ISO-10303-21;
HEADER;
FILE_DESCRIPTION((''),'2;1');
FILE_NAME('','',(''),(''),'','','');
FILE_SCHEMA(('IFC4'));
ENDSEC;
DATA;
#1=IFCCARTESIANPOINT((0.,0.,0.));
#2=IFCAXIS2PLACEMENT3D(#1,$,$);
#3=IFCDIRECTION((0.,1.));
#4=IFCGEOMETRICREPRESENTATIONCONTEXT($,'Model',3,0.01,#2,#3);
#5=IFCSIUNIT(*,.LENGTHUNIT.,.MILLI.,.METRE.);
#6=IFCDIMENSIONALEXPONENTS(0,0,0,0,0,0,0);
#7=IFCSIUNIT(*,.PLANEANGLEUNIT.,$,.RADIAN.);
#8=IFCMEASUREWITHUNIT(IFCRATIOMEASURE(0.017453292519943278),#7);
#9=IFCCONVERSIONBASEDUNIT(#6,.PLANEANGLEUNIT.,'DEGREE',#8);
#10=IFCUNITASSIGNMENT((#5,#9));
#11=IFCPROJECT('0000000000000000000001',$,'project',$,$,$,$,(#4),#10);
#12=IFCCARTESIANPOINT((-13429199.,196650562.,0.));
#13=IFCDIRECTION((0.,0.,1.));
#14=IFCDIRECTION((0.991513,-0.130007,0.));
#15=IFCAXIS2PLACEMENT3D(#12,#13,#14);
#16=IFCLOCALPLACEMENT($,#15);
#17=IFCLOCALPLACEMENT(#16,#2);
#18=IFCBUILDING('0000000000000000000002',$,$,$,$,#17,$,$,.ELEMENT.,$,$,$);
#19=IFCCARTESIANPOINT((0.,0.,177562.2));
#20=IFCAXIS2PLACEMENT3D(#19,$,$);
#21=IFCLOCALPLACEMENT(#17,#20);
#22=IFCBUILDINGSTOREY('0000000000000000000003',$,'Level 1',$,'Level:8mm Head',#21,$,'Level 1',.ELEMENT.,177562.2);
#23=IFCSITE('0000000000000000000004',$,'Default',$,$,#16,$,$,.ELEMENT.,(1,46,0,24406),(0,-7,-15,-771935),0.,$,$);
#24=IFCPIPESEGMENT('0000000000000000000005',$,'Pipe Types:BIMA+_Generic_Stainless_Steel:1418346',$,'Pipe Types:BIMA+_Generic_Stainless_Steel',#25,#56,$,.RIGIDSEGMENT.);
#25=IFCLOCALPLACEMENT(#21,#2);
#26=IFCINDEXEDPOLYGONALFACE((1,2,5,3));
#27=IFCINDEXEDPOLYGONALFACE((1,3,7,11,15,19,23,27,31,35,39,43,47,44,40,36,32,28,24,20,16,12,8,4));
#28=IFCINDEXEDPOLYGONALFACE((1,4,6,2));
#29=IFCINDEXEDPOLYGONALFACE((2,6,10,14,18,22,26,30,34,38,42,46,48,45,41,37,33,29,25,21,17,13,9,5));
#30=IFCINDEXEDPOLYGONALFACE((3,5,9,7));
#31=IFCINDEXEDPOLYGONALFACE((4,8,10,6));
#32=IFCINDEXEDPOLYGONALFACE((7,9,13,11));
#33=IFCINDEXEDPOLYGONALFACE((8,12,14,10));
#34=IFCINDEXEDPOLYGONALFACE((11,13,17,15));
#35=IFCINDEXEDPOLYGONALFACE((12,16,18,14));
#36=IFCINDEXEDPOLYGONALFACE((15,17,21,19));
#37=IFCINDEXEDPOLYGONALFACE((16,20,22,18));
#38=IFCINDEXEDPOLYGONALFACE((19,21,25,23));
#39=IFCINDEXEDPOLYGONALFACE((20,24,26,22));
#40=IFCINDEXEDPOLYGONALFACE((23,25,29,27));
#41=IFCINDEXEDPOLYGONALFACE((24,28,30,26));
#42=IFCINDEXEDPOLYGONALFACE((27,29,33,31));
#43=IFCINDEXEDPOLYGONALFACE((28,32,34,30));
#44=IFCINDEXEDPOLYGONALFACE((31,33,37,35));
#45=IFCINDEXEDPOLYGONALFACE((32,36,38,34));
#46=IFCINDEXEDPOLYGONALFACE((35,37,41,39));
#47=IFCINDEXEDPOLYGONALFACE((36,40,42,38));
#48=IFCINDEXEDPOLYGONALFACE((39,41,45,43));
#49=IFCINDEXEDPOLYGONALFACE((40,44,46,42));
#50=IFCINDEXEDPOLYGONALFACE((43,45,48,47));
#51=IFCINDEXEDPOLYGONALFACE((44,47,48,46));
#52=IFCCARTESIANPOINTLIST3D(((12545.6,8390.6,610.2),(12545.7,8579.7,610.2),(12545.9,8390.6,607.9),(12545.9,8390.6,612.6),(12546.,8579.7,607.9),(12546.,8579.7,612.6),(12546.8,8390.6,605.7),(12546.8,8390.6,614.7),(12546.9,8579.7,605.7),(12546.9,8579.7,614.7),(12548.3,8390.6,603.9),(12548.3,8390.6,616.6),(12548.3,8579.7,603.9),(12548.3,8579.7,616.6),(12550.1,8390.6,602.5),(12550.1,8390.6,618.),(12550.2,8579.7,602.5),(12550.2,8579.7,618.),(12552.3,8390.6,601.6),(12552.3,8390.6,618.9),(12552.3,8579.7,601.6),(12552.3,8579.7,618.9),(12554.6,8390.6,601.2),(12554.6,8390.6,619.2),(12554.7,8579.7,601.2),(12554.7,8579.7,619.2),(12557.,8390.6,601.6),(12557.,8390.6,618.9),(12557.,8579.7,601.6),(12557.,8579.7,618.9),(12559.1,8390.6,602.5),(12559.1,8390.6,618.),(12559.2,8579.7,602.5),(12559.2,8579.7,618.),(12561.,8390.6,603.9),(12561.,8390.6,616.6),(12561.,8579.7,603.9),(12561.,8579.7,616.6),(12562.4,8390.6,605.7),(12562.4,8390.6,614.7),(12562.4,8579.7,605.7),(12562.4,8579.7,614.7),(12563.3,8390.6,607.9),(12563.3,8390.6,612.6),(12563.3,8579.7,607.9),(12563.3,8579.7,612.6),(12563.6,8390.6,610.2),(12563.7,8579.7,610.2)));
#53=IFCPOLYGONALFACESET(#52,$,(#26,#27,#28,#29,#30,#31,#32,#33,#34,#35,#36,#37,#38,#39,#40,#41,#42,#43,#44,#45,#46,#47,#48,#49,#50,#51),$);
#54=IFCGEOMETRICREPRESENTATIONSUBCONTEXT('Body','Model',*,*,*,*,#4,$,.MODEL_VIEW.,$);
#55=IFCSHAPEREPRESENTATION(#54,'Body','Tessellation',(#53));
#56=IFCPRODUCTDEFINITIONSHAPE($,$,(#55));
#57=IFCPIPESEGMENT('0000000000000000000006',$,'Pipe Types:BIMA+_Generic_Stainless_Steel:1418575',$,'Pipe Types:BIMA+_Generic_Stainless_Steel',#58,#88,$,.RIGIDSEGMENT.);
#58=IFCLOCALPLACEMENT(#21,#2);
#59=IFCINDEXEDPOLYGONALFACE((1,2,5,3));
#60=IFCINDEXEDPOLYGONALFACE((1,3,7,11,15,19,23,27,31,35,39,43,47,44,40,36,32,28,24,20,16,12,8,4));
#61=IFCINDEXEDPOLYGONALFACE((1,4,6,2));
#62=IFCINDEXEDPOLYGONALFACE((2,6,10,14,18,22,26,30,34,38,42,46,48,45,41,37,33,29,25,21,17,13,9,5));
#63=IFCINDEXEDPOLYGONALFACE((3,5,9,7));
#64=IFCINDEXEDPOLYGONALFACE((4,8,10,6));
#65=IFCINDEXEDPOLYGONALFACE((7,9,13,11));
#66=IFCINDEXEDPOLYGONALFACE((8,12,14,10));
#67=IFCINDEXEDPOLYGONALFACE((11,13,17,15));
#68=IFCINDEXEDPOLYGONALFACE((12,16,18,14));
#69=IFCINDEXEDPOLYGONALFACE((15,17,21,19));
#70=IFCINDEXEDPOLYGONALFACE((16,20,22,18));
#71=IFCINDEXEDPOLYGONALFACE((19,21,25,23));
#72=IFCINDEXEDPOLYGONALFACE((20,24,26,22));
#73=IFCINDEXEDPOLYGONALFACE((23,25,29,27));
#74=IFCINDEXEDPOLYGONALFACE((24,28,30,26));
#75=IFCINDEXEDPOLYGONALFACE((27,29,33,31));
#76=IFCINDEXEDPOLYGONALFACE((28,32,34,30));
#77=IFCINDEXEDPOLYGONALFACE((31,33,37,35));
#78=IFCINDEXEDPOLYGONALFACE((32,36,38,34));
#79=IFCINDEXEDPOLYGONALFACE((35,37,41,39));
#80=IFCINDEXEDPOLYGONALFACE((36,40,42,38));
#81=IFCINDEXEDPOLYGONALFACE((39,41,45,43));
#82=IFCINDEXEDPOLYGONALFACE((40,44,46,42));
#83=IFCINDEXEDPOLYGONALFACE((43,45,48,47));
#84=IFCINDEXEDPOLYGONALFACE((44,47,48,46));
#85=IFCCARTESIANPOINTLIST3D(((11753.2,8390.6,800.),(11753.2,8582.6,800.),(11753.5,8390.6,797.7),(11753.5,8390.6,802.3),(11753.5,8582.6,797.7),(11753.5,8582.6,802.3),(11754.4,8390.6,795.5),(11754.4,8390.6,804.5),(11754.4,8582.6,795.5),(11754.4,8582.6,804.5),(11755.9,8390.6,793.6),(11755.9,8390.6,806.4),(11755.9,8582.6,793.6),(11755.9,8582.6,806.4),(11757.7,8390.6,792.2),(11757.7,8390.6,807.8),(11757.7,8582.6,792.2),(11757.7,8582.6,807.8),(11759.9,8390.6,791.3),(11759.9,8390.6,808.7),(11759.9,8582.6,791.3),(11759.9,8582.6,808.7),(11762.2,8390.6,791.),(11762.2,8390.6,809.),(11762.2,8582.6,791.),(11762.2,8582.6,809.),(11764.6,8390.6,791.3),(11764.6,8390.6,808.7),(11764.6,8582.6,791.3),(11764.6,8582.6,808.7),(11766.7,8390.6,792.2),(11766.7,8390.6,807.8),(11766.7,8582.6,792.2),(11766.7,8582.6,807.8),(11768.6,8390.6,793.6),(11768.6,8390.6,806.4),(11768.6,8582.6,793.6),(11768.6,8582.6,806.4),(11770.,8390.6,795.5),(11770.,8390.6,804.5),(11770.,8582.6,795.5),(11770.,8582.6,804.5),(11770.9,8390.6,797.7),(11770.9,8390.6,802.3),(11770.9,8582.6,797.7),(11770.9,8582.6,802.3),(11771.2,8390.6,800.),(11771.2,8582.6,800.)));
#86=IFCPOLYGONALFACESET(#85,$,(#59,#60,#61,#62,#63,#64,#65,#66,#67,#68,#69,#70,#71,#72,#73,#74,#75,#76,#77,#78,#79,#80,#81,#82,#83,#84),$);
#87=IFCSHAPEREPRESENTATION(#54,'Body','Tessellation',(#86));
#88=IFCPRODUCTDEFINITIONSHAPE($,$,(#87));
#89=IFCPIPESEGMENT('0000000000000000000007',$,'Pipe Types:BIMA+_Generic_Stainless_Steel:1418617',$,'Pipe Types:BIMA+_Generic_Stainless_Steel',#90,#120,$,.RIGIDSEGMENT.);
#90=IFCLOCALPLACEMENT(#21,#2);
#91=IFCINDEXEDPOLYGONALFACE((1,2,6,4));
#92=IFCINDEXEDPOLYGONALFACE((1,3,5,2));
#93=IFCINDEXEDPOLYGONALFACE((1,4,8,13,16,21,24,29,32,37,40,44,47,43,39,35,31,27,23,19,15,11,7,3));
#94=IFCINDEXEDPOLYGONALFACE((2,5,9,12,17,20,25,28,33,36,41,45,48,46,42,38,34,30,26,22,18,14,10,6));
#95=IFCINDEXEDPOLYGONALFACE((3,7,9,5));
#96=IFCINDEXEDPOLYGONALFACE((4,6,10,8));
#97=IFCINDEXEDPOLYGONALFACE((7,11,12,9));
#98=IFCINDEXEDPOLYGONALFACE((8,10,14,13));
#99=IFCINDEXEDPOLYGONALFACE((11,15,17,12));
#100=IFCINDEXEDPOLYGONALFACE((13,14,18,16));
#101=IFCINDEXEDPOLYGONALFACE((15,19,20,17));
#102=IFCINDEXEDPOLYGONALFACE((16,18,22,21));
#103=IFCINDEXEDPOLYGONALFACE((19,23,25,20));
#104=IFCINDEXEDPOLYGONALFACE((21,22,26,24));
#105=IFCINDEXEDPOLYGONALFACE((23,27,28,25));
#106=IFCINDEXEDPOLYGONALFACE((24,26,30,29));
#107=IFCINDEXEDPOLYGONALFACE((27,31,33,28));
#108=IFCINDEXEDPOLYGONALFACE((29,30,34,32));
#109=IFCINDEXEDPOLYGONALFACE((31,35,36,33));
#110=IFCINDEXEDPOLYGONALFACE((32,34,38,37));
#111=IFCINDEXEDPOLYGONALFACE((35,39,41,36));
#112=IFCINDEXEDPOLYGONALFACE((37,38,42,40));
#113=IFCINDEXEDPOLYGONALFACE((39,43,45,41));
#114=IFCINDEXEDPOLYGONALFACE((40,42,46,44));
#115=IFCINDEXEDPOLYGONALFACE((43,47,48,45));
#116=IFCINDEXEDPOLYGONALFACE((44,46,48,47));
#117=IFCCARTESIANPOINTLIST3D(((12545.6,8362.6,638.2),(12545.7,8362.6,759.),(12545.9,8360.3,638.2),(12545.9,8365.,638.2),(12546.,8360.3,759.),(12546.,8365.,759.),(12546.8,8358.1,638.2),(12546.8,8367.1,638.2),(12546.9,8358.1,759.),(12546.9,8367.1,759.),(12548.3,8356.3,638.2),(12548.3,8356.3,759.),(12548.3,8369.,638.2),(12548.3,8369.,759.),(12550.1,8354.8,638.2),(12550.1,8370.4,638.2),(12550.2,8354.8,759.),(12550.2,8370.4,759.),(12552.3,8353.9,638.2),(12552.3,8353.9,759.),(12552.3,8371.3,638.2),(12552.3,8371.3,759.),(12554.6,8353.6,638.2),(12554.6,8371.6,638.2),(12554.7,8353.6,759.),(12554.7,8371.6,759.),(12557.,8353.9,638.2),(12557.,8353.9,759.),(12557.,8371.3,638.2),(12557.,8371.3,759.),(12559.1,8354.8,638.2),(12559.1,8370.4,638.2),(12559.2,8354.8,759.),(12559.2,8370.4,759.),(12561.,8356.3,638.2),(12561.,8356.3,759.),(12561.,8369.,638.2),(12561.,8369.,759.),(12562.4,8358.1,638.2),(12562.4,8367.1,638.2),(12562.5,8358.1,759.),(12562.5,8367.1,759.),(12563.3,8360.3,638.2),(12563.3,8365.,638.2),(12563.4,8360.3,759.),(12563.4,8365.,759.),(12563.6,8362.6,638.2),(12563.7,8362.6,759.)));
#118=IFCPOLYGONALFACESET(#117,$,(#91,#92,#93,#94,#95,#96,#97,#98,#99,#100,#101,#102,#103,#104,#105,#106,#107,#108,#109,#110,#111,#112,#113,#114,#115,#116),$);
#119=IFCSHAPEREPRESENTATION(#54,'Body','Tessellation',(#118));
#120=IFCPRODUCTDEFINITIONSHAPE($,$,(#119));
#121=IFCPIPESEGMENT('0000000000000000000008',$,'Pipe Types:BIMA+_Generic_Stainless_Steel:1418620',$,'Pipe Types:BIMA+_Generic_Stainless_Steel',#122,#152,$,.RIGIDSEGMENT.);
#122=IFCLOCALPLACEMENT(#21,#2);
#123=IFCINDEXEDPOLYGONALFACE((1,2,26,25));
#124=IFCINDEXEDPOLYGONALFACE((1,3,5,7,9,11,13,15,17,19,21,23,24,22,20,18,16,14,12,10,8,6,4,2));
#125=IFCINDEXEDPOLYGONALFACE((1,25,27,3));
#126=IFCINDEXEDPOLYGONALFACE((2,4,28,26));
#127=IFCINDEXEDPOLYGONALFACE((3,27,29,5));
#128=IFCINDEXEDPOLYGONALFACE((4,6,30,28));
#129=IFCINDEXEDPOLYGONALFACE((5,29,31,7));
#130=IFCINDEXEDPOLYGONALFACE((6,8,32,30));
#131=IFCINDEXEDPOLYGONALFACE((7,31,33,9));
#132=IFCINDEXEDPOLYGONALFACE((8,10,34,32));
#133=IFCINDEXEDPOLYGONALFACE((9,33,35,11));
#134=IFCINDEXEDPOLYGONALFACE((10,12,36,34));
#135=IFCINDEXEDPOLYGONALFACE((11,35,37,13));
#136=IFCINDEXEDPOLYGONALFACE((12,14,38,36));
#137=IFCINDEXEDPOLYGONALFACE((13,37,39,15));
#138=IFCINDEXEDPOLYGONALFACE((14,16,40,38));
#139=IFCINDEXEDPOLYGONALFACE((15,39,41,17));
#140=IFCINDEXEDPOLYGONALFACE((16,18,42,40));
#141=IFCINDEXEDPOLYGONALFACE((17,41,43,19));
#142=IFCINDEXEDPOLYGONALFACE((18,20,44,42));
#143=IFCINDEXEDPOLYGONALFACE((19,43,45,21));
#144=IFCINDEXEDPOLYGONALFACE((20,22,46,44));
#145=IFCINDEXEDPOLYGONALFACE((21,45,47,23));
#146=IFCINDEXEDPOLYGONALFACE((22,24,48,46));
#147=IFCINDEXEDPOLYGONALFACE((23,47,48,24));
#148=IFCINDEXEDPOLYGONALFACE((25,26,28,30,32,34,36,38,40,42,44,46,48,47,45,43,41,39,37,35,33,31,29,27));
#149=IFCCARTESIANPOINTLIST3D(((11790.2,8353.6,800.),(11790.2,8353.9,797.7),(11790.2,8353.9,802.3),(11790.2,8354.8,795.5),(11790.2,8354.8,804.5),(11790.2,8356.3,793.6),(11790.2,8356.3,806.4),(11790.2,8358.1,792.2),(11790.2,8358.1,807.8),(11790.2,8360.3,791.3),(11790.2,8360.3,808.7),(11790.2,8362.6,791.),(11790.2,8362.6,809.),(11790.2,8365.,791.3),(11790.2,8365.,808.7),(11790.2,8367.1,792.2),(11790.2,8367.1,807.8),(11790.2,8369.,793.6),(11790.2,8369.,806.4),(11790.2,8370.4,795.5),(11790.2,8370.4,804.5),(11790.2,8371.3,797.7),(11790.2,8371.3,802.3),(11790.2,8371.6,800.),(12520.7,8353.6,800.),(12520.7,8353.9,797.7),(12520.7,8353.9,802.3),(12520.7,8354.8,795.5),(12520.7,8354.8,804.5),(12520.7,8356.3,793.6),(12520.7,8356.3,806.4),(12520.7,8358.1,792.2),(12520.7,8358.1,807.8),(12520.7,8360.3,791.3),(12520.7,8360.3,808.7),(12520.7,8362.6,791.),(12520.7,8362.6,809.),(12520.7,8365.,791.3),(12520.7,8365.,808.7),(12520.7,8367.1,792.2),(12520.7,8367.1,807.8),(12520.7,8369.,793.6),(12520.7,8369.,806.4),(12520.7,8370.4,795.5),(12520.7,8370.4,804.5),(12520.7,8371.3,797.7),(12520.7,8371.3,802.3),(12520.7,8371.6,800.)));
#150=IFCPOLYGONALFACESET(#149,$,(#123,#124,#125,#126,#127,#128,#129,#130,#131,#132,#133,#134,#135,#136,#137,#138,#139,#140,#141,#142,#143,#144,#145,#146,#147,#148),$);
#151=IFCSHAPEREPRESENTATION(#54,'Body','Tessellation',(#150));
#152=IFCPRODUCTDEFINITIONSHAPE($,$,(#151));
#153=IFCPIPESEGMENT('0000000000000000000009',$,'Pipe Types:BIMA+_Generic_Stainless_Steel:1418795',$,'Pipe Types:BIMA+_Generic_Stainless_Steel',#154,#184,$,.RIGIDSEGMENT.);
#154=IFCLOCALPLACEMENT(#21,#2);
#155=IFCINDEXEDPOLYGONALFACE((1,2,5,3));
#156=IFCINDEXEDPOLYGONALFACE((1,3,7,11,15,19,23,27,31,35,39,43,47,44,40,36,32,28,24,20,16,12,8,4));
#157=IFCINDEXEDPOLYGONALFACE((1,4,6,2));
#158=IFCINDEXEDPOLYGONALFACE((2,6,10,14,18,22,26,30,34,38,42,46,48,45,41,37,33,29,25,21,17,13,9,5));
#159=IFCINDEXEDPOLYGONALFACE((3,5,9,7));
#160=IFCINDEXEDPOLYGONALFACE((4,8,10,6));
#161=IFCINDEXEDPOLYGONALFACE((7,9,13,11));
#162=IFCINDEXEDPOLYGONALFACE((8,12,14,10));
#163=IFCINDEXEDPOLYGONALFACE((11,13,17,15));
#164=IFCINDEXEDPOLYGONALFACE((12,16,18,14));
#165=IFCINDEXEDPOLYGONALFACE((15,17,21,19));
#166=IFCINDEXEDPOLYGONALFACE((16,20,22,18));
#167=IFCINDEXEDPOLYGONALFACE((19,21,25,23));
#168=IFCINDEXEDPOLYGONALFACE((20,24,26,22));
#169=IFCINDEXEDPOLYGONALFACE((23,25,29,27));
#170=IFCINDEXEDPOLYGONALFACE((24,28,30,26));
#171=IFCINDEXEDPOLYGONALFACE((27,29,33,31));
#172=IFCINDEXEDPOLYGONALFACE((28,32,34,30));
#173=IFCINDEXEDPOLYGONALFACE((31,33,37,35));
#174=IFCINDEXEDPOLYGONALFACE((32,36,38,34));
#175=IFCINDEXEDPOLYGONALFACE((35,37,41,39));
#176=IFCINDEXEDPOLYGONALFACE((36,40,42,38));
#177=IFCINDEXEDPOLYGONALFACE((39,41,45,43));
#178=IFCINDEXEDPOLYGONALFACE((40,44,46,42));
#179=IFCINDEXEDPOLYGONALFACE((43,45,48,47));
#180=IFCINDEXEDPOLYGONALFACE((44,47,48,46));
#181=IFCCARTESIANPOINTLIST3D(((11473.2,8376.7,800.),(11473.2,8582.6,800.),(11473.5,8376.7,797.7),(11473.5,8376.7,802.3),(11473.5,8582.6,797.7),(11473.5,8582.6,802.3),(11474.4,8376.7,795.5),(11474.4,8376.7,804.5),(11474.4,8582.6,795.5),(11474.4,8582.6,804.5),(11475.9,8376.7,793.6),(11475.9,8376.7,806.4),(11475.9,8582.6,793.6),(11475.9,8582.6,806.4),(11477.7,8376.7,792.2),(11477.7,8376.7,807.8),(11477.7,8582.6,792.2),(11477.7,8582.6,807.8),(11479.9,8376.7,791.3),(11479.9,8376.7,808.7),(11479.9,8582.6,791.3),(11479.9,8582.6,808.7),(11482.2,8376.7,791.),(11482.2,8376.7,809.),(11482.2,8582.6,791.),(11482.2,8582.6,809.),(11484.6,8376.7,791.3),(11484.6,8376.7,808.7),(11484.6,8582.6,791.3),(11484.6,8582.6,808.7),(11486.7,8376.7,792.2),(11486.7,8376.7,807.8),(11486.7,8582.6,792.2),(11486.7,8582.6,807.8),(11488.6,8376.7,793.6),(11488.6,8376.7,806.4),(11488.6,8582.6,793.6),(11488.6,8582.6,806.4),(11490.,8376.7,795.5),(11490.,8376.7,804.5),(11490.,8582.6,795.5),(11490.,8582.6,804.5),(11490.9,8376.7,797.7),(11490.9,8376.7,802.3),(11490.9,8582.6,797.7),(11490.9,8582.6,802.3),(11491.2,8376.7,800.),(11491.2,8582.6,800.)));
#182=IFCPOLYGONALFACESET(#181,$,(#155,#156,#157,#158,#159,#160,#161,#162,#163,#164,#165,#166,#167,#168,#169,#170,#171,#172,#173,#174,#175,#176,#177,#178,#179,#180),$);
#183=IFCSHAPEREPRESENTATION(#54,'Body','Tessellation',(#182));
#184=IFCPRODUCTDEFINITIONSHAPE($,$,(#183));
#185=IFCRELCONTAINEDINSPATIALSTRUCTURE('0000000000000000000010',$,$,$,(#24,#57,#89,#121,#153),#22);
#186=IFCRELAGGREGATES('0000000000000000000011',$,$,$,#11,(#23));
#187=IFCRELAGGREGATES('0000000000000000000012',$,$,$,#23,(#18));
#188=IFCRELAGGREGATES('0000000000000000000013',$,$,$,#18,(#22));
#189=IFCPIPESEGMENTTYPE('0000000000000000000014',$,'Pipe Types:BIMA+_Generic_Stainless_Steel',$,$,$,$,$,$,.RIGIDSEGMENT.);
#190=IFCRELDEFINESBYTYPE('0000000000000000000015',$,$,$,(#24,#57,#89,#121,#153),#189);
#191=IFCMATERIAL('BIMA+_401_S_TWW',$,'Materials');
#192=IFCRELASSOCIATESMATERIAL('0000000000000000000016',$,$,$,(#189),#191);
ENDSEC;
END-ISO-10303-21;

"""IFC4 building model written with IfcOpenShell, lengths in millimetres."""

from ifc_helpers import new_model, entity, si_unit, converted_unit, direction, frame, origin, place, context, subcontext, project, spatial, arc, indexed_curve, outline, extrude, material, type_object, element, save


model = new_model("IFC4")

# Units and contexts
model_context = context("Model", 3, precision=0.01, world=origin(), true_north=direction((0.0, 1.0)))
body_context = subcontext(model_context, "Body", "Model", "MODEL_VIEW")
ifc_project = project(units=[si_unit("LENGTHUNIT", "METRE", prefix="MILLI"), converted_unit("PLANEANGLEUNIT", "DEGREE", entity("IfcRatioMeasure", 0.017453292519943278), si_unit("PLANEANGLEUNIT", "RADIAN"), dimensions=[0, 0, 0, 0, 0, 0, 0])], contexts=[model_context])

# Site, building, storey
site_placement = place(None, frame((-13429199.0, 196650562.0, 0.0), z_axis=(0.0, 0.0, 1.0), x_axis=(0.991513, -0.130007, 0.0)))
site = spatial("IfcSite", under=ifc_project, at=site_placement, Name="Default", CompositionType="ELEMENT", RefLatitude=(1, 46, 0, 24406), RefLongitude=(0, -7, -15, -771935), RefElevation=0.0)
building_placement = place(site_placement, origin())
building = spatial("IfcBuilding", under=site, at=building_placement, CompositionType="ELEMENT")
storey_placement = place(building_placement, frame((0.0, 0.0, 177562.2)))
storey = spatial("IfcBuildingStorey", under=building, at=storey_placement, Name="Level 1", ObjectType="Level:8mm Head", LongName="Level 1", CompositionType="ELEMENT", Elevation=177562.2)

# Pipe segments
ifc_material_1 = material(Name="BIMA+_401_S_TWW", Category="Materials")
pipe_segment_type_1 = type_object("IfcPipeSegmentType", Name="Pipe Types:BIMA+_Generic_Stainless_Steel", PredefinedType="RIGIDSEGMENT", material=ifc_material_1)
pipe_segment_1_placement = place(storey_placement, frame((12544.0, 8390.6, 599.6)))
element("IfcPipeSegment", 1, at=pipe_segment_1_placement, inside=storey, type_object=pipe_segment_type_1, Name="Pipe Types:BIMA+_Generic_Stainless_Steel:1418346", ObjectType="Pipe Types:BIMA+_Generic_Stainless_Steel", PredefinedType="RIGIDSEGMENT", context=body_context, shape_type="SweptSolid", body=[
    extrude(outline(indexed_curve([(9.0, 0.0), (6.4, 6.4), (0.0, 9.0), (-6.4, 6.4), (-9.0, 0.0), (-6.4, -6.4), (0.0, -9.0), (6.4, -6.4)], segments=[arc(1, 2, 3), arc(3, 4, 5), arc(5, 6, 7), arc(7, 8, 1)], self_intersect=False)), frame((10.6, 0.0, 10.6), z_axis=(0.000062, 1.0, 0.0), x_axis=(1.0, -0.000062, 0.0)), (0.0, 0.0, 1.0), 189.0),
])
pipe_segment_2_placement = place(storey_placement, frame((11751.6, 8390.6, 789.4)))
element("IfcPipeSegment", 2, at=pipe_segment_2_placement, inside=storey, type_object=pipe_segment_type_1, Name="Pipe Types:BIMA+_Generic_Stainless_Steel:1418575", ObjectType="Pipe Types:BIMA+_Generic_Stainless_Steel", PredefinedType="RIGIDSEGMENT", context=body_context, shape_type="SweptSolid", body=[
    extrude(outline(indexed_curve([(9.0, 0.0), (6.4, 6.4), (0.0, 9.0), (-6.4, 6.4), (-9.0, 0.0), (-6.4, -6.4), (0.0, -9.0), (6.4, -6.4)], segments=[arc(1, 2, 3), arc(3, 4, 5), arc(5, 6, 7), arc(7, 8, 1)], self_intersect=False)), frame((10.6, 0.0, 10.6), z_axis=(0.0, 1.0, 0.0), x_axis=(-1.0, 0.0, 0.0)), (0.0, 0.0, 1.0), 192.0),
])
pipe_segment_3_placement = place(storey_placement, frame((12544.0, 8352.0, 638.2)))
element("IfcPipeSegment", 3, at=pipe_segment_3_placement, inside=storey, type_object=pipe_segment_type_1, Name="Pipe Types:BIMA+_Generic_Stainless_Steel:1418617", ObjectType="Pipe Types:BIMA+_Generic_Stainless_Steel", PredefinedType="RIGIDSEGMENT", context=body_context, shape_type="SweptSolid", body=[
    extrude(outline(indexed_curve([(9.0, 0.0), (6.4, 6.4), (0.0, 9.0), (-6.4, 6.4), (-9.0, 0.0), (-6.4, -6.4), (0.0, -9.0), (6.4, -6.4)], segments=[arc(1, 2, 3), arc(3, 4, 5), arc(5, 6, 7), arc(7, 8, 1)], self_intersect=False)), frame((10.6, 10.6, 0.0), z_axis=(0.00029, 0.0, 1.0), x_axis=(1.0, 0.0, -0.00029)), (0.0, 0.0, 1.0), 120.8),
])
pipe_segment_4_placement = place(storey_placement, frame((11790.2, 8352.0, 789.4)))
element("IfcPipeSegment", 4, at=pipe_segment_4_placement, inside=storey, type_object=pipe_segment_type_1, Name="Pipe Types:BIMA+_Generic_Stainless_Steel:1418620", ObjectType="Pipe Types:BIMA+_Generic_Stainless_Steel", PredefinedType="RIGIDSEGMENT", context=body_context, shape_type="SweptSolid", body=[
    extrude(outline(indexed_curve([(9.0, 0.0), (6.4, 6.4), (0.0, 9.0), (-6.4, 6.4), (-9.0, 0.0), (-6.4, -6.4), (0.0, -9.0), (6.4, -6.4)], segments=[arc(1, 2, 3), arc(3, 4, 5), arc(5, 6, 7), arc(7, 8, 1)], self_intersect=False)), frame((0.0, 10.6, 10.6), z_axis=(1.0, 0.0, 0.0), x_axis=(0.0, -1.0, 0.0)), (0.0, 0.0, 1.0), 730.4),
])
pipe_segment_5_placement = place(storey_placement, frame((11471.6, 8376.7, 789.4)))
element("IfcPipeSegment", 5, at=pipe_segment_5_placement, inside=storey, type_object=pipe_segment_type_1, Name="Pipe Types:BIMA+_Generic_Stainless_Steel:1418795", ObjectType="Pipe Types:BIMA+_Generic_Stainless_Steel", PredefinedType="RIGIDSEGMENT", context=body_context, shape_type="SweptSolid", body=[
    extrude(outline(indexed_curve([(9.0, 0.0), (6.4, 6.4), (0.0, 9.0), (-6.4, 6.4), (-9.0, 0.0), (-6.4, -6.4), (0.0, -9.0), (6.4, -6.4)], segments=[arc(1, 2, 3), arc(3, 4, 5), arc(5, 6, 7), arc(7, 8, 1)], self_intersect=False)), frame((10.6, 0.0, 10.6), z_axis=(0.0, 1.0, 0.0), x_axis=(-1.0, 0.0, 0.0)), (0.0, 0.0, 1.0), 205.9),
])

save(model, "model.ifc")
